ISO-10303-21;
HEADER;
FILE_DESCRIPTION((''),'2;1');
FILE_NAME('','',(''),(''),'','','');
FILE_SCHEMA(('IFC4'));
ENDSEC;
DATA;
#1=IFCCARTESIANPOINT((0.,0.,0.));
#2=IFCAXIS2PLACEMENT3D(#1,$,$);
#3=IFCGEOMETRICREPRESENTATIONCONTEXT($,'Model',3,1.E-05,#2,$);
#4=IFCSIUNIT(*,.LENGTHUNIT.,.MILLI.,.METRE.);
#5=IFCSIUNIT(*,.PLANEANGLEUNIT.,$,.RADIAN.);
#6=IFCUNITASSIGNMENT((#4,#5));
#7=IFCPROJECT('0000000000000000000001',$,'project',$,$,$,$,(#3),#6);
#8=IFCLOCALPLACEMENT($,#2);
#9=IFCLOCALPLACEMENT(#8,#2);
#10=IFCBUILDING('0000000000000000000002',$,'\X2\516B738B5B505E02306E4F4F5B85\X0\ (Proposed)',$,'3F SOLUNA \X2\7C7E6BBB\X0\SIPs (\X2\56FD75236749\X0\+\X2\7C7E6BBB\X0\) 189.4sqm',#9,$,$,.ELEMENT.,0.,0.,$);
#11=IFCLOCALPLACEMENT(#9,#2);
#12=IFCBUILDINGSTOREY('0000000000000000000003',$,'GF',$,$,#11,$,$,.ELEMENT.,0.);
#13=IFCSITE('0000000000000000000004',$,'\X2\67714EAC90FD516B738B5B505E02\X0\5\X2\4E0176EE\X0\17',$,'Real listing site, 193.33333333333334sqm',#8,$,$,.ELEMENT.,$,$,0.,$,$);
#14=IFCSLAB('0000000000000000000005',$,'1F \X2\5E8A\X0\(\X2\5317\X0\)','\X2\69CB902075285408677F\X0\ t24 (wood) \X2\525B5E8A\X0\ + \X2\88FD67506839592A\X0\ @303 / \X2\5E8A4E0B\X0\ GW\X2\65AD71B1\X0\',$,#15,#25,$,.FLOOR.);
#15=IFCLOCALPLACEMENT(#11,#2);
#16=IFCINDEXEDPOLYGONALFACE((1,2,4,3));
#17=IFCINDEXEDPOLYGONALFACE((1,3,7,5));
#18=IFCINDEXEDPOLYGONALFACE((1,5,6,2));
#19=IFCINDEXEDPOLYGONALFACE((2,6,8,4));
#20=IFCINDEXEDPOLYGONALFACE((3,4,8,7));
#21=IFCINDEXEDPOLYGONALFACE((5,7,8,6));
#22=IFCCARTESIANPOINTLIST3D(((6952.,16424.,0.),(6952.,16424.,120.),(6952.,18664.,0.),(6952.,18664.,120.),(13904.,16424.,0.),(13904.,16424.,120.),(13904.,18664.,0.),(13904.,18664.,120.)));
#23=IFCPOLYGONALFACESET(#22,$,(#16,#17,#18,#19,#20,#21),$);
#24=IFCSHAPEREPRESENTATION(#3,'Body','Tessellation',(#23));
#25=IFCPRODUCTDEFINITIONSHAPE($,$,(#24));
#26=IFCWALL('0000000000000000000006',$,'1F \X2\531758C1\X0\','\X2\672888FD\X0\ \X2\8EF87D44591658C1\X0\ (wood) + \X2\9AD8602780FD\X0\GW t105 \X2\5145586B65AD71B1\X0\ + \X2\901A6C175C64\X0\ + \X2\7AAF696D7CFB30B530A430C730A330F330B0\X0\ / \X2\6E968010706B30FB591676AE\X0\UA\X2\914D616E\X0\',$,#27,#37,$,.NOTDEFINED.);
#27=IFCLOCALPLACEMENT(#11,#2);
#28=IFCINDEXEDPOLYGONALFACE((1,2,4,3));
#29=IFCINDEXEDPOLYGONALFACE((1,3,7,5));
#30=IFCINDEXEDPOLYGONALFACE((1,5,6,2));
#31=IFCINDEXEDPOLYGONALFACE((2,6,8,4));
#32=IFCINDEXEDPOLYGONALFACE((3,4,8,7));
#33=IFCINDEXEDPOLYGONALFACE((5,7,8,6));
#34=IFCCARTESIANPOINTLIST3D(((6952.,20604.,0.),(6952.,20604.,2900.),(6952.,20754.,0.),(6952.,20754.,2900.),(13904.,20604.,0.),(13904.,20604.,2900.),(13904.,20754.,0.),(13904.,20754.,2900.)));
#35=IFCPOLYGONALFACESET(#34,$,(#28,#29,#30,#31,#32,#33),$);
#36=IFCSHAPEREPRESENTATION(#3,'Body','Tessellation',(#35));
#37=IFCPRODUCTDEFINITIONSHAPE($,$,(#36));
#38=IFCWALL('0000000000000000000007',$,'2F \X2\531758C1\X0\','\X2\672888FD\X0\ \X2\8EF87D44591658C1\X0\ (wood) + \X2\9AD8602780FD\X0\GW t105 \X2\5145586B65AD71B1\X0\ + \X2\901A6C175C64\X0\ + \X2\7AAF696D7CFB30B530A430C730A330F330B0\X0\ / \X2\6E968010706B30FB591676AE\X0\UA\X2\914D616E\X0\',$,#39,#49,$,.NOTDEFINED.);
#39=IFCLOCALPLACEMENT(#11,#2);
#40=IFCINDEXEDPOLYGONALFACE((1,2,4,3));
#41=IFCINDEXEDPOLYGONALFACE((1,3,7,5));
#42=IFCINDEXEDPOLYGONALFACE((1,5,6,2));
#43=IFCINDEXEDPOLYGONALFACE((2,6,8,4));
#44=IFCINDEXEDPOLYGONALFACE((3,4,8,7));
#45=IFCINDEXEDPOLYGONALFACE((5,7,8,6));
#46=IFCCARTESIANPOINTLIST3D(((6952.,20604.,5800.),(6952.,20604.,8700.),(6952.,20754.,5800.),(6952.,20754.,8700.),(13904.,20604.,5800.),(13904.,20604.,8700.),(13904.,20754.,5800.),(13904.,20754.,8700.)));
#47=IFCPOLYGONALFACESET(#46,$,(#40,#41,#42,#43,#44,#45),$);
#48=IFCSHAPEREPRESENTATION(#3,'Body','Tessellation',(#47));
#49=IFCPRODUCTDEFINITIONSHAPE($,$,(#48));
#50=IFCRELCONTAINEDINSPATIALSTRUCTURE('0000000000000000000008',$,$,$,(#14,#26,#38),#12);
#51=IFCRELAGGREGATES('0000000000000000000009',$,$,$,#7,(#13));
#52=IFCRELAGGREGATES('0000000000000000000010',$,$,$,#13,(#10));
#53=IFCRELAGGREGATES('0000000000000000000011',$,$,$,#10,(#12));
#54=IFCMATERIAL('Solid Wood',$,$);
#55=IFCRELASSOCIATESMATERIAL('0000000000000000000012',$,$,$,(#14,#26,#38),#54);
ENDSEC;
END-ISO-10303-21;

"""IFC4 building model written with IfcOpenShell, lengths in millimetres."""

from ifc_helpers import new_model, si_unit, frame, frame_2d, origin, place, context, project, spatial, rectangle, extrude, material, element, save


model = new_model("IFC4")

# Units and contexts
model_context = context("Model", 3, precision=1e-05, world=origin())
ifc_project = project(units=[si_unit("LENGTHUNIT", "METRE", prefix="MILLI"), si_unit("PLANEANGLEUNIT", "RADIAN")], contexts=[model_context])

# Site, building, storey
site_placement = place(None, origin())
site = spatial("IfcSite", under=ifc_project, at=site_placement, Name="東京都八王子市5丁目17", ObjectType="Real listing site, 193.33333333333334sqm", CompositionType="ELEMENT", RefElevation=0.0)
building_placement = place(site_placement, origin())
building = spatial("IfcBuilding", under=site, at=building_placement, Name="八王子市の住宅 (Proposed)", ObjectType="3F SOLUNA 籾殻SIPs (国産杉+籾殻) 189.4sqm", CompositionType="ELEMENT", ElevationOfRefHeight=0.0, ElevationOfTerrain=0.0)
storey_placement = place(building_placement, origin())
storey = spatial("IfcBuildingStorey", under=building, at=storey_placement, Name="GF", CompositionType="ELEMENT", Elevation=0.0)

# Slab
ifc_material_1 = material(Name="Solid Wood")
slab_1_placement = place(storey_placement, frame((3476.0, 8212.0, 0.0)))
element("IfcSlab", 1, at=slab_1_placement, inside=storey, material=ifc_material_1, Name="1F 床(北)", Description="構造用合板 t24 (wood) 剛床 + 製材根太 @303 / 床下 GW断熱", PredefinedType="FLOOR", context=model_context, shape_type="SweptSolid", body=[
    extrude(rectangle(XDim=6952.0, YDim=2240.0, at=frame_2d((3476.0, 1120.0))), frame((3476.0, 8212.0, 0.0)), (0.0, 0.0, 1.0), 120.0),
])

# Wall
wall_1_placement = place(storey_placement, frame((3476.0, 10302.0, 0.0)))
element("IfcWall", 2, at=wall_1_placement, inside=storey, material=ifc_material_1, Name="1F 北壁", Description="木製 軸組外壁 (wood) + 高性能GW t105 充填断熱 + 通気層 + 窯業系サイディング / 準耐火・外皮UA配慮", PredefinedType="NOTDEFINED", context=model_context, shape_type="SweptSolid", body=[
    extrude(rectangle(XDim=6952.0, YDim=150.0, at=frame_2d((3476.0, 75.0))), frame((3476.0, 10302.0, 0.0)), (0.0, 0.0, 1.0), 2900.0),
])

# Wall
wall_2_placement = place(storey_placement, frame((3476.0, 10302.0, 2900.0)))
element("IfcWall", 3, at=wall_2_placement, inside=storey, material=ifc_material_1, Name="2F 北壁", Description="木製 軸組外壁 (wood) + 高性能GW t105 充填断熱 + 通気層 + 窯業系サイディング / 準耐火・外皮UA配慮", PredefinedType="NOTDEFINED", context=model_context, shape_type="SweptSolid", body=[
    extrude(rectangle(XDim=6952.0, YDim=150.0, at=frame_2d((3476.0, 75.0))), frame((3476.0, 10302.0, 2900.0)), (0.0, 0.0, 1.0), 2900.0),
])

save(model, "model.ifc")
